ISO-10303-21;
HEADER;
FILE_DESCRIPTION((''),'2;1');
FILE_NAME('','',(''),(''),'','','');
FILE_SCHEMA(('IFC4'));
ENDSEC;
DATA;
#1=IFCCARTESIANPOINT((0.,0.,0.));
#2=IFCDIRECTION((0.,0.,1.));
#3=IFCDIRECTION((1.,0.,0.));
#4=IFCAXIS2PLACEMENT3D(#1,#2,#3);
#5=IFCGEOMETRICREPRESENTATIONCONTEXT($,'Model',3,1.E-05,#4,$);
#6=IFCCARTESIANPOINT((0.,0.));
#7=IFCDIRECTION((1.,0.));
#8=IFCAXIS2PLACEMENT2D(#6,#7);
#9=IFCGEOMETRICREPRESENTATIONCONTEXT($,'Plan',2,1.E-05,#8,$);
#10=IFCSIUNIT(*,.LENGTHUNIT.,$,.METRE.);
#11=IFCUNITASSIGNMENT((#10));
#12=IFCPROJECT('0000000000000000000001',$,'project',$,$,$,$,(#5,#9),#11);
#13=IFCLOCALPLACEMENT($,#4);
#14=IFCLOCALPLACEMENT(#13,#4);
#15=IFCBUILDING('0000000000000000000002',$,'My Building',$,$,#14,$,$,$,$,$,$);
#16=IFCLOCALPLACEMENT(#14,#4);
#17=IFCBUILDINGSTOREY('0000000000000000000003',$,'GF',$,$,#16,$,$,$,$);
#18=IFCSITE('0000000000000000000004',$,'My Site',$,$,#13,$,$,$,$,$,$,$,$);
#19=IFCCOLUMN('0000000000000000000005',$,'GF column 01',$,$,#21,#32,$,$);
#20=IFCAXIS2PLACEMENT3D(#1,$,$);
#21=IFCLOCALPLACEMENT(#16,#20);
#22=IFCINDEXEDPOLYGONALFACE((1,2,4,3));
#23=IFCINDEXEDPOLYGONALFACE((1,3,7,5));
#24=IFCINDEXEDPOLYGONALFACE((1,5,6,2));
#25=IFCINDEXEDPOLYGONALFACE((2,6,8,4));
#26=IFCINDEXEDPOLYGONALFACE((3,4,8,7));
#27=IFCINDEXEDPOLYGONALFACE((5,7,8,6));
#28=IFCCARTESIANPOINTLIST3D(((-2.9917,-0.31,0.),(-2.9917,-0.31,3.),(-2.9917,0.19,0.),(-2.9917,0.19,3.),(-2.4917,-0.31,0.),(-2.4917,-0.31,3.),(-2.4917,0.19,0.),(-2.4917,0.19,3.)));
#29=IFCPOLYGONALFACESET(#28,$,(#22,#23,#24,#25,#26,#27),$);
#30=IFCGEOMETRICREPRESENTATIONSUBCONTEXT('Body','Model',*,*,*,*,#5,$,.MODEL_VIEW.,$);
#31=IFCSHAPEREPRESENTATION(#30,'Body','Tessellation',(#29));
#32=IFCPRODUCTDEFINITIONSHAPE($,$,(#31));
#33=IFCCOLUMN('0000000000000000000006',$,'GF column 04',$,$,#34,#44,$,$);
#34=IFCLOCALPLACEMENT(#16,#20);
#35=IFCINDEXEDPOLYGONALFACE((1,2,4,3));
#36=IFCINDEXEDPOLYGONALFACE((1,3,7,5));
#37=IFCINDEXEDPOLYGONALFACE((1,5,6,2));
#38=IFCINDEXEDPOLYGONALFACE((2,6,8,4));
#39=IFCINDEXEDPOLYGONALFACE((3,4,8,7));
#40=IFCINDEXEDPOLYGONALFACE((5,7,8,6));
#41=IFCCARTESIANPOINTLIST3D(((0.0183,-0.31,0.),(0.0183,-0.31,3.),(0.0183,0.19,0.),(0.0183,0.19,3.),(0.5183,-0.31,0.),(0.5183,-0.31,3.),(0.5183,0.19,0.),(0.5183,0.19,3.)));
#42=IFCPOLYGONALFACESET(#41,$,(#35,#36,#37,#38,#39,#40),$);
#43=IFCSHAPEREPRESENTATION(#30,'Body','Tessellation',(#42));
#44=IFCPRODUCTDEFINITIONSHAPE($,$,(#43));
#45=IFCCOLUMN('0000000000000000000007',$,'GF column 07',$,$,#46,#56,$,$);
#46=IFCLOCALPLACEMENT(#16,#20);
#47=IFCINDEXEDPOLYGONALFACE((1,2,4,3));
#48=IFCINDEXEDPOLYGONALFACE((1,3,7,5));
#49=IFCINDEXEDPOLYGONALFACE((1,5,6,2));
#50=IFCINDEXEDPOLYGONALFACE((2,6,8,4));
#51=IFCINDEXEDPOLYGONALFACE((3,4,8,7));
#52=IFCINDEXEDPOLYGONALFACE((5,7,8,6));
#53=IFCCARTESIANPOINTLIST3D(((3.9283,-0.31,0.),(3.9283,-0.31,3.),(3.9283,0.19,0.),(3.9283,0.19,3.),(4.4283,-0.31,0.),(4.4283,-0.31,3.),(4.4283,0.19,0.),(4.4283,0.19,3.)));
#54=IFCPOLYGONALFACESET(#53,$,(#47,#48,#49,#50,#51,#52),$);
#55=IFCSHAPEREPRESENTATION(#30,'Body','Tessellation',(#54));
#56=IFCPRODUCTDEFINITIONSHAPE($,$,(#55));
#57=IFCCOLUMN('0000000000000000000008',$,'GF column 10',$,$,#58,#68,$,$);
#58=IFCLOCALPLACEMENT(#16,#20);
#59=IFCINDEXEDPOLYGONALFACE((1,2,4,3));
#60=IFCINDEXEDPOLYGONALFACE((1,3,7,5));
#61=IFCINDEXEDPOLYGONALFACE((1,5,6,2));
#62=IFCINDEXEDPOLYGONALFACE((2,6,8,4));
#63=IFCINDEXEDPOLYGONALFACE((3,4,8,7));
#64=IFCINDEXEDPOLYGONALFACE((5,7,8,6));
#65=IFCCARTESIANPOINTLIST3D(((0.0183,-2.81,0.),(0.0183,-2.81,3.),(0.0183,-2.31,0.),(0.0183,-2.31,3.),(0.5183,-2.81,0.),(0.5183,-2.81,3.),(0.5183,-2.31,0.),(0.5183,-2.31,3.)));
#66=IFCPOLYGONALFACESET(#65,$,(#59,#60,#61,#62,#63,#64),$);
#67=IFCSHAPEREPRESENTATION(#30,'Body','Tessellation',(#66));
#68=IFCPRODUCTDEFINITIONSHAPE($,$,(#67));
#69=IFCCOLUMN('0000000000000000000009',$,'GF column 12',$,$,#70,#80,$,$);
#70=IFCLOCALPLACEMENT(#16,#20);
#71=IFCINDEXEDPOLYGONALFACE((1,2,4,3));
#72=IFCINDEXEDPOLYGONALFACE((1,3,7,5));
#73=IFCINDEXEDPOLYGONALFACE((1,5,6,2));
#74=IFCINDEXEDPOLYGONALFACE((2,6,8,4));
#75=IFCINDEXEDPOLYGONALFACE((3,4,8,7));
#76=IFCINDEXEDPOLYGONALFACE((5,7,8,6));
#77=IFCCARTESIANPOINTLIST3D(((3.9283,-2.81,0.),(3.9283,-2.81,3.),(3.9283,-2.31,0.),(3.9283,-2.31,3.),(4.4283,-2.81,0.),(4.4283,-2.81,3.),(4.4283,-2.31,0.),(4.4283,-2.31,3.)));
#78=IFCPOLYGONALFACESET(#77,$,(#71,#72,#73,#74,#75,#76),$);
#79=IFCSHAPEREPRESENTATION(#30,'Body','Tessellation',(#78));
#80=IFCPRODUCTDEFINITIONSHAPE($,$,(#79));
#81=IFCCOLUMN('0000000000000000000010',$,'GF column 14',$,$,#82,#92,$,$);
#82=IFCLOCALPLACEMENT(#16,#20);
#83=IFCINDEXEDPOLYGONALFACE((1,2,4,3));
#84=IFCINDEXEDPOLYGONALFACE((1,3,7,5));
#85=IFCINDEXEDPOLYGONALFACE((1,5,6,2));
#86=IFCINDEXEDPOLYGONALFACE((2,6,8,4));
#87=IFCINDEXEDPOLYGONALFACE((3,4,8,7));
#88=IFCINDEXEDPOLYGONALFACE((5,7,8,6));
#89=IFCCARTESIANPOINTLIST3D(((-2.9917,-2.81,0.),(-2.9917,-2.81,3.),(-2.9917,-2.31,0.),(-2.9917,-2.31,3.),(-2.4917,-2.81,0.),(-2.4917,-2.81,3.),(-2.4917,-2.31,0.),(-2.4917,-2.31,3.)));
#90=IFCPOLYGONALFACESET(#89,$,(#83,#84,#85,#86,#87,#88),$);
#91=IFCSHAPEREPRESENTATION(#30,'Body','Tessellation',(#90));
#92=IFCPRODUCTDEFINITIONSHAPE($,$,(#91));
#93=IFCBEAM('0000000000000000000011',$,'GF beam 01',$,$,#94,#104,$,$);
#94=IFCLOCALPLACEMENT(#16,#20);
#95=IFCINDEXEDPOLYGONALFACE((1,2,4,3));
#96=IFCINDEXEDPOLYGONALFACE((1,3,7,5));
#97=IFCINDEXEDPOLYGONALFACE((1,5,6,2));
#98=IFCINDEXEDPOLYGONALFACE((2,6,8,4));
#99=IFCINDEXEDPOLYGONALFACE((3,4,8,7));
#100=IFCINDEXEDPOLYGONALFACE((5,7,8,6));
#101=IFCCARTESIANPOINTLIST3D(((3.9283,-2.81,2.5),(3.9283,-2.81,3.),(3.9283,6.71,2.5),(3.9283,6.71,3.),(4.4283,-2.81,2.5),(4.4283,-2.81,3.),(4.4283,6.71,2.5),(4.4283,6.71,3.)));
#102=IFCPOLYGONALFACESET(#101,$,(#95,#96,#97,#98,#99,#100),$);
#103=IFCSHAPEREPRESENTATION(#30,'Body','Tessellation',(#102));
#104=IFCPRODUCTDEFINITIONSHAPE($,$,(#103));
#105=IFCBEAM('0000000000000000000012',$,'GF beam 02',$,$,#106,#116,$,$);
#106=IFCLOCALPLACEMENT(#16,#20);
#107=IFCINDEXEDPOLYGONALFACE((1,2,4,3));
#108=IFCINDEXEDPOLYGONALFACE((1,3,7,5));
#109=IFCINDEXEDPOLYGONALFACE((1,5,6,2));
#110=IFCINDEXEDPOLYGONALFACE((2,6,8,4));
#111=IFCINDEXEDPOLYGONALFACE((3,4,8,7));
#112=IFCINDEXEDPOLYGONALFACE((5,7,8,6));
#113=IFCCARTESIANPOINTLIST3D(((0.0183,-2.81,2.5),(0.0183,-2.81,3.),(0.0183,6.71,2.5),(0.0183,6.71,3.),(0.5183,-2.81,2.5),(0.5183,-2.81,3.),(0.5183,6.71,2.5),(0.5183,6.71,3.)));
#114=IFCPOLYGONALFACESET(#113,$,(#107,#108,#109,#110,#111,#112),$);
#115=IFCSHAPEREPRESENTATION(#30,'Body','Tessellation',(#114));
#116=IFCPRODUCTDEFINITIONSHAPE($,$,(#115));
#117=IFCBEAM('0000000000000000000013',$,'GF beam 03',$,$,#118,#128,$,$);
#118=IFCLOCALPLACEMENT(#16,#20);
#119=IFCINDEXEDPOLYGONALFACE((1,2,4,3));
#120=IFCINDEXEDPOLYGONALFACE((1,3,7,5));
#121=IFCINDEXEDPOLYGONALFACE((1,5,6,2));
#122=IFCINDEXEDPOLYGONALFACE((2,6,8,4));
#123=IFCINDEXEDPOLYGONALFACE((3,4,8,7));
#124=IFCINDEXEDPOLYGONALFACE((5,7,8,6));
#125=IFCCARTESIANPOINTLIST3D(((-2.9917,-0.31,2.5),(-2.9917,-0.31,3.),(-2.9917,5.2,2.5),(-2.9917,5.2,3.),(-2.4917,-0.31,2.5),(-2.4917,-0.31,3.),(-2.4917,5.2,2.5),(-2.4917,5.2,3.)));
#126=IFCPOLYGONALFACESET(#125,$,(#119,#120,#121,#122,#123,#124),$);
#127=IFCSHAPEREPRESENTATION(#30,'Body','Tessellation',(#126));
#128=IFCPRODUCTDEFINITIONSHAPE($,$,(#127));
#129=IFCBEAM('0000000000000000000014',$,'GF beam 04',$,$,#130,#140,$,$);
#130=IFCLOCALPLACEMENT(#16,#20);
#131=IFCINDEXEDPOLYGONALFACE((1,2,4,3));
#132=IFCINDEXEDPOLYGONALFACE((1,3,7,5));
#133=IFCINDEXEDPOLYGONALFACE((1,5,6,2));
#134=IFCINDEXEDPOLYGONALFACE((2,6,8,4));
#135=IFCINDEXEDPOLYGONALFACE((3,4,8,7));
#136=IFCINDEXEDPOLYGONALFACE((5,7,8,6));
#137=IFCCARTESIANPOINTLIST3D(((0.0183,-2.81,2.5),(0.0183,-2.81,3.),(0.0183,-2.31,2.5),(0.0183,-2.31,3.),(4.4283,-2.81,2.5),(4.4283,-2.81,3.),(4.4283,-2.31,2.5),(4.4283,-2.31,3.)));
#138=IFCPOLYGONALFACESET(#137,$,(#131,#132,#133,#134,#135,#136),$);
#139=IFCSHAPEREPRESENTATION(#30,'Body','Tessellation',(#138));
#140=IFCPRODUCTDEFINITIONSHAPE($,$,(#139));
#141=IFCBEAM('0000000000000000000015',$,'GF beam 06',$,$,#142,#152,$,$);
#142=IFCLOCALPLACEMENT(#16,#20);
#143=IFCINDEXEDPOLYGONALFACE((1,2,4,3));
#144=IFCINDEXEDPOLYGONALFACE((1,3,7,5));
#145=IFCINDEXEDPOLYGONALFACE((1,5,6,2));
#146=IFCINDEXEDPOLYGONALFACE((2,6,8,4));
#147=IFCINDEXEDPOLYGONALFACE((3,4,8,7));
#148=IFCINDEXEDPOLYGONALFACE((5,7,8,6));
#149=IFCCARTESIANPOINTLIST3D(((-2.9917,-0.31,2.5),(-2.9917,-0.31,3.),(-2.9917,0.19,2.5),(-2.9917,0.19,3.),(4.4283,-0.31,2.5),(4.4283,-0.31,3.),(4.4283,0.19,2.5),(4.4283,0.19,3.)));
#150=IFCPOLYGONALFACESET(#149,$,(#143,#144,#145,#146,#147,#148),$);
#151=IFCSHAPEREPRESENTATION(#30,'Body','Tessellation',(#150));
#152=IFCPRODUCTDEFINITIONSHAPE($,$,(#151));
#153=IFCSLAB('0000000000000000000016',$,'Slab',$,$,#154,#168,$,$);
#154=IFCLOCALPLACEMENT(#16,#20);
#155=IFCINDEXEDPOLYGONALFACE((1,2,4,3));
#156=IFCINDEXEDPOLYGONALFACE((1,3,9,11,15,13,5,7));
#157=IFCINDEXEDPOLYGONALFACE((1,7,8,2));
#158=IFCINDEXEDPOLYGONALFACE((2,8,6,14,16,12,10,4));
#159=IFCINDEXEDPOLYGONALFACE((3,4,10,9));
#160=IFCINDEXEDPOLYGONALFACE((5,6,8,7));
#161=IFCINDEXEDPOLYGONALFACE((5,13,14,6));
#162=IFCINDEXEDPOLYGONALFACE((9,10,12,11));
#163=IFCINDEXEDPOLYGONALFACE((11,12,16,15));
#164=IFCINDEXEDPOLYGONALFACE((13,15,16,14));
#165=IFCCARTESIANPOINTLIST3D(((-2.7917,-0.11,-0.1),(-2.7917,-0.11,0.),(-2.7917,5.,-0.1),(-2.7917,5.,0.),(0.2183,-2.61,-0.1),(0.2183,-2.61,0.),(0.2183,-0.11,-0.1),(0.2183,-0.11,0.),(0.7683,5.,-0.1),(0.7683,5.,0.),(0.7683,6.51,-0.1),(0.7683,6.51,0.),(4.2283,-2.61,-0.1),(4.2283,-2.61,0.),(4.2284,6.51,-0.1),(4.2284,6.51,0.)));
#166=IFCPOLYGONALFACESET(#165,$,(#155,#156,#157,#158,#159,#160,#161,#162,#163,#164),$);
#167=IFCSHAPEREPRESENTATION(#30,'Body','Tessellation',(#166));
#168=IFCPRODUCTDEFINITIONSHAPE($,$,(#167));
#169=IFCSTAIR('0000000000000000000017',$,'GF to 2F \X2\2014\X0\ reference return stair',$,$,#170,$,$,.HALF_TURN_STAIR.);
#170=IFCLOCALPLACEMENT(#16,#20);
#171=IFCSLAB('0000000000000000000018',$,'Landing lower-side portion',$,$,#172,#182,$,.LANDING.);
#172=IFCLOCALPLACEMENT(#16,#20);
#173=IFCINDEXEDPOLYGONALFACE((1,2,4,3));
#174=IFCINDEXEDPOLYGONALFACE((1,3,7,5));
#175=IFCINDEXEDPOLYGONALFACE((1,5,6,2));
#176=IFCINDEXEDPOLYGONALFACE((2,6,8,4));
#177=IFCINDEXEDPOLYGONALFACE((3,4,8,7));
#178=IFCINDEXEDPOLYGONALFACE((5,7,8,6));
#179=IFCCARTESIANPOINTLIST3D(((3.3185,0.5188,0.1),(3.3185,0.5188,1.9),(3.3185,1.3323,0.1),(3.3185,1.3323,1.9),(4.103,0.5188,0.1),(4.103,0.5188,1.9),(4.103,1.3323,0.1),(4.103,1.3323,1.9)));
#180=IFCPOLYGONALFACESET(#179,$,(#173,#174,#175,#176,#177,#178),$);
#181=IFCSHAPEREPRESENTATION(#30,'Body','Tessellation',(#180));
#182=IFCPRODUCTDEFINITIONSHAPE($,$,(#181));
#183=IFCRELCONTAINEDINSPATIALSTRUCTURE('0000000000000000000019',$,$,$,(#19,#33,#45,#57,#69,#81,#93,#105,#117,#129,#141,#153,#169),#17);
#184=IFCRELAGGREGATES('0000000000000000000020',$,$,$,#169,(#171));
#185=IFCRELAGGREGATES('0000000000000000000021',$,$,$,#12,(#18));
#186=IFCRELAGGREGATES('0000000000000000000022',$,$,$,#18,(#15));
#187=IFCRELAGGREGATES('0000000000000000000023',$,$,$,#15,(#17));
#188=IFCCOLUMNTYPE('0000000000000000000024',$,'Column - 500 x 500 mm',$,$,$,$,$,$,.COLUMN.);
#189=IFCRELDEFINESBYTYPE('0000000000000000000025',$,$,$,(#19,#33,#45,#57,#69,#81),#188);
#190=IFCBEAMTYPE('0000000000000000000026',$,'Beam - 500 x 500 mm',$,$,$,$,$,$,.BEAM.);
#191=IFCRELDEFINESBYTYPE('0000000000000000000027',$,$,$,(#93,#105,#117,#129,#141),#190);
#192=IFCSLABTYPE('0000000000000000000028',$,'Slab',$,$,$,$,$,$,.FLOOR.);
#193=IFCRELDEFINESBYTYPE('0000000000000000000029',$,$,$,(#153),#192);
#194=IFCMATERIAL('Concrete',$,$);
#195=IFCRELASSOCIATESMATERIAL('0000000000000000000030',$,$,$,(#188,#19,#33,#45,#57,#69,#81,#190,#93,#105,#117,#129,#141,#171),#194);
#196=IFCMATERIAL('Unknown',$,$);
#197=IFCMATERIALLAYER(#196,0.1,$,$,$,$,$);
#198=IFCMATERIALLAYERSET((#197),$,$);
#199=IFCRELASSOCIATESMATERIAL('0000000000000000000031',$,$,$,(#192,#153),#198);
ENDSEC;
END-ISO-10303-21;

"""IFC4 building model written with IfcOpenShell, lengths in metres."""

from ifc_helpers import new_model, si_unit, frame, origin_with_axes, origin_2d_with_axis, place, context, subcontext, project, spatial, indexed_curve, rectangle, outline, extrude, material, layer, layer_set, layer_usage, material_profile, profile_set, profile_usage, type_object, element, aggregate, save


model = new_model("IFC4")

# Units and contexts
model_context_1 = context("Model", 3, precision=1e-05, world=origin_with_axes())
plan_context = context("Plan", 2, precision=1e-05, world=origin_2d_with_axis())
body_context_1 = subcontext(model_context_1, "Body", "Model", "MODEL_VIEW")
ifc_project = project(units=[si_unit("LENGTHUNIT", "METRE")], contexts=[model_context_1, plan_context])

# Site, building, storey
site_placement = place(None, origin_with_axes())
site = spatial("IfcSite", under=ifc_project, at=site_placement, Name="My Site")
building_placement = place(site_placement, origin_with_axes())
building = spatial("IfcBuilding", under=site, at=building_placement, Name="My Building")
storey_placement = place(building_placement, origin_with_axes())
storey = spatial("IfcBuildingStorey", under=building, at=storey_placement, Name="GF")

# Columns
ifc_material_1 = material(Name="Concrete")
ifc_material_profile_1 = material_profile(ifc_material_1, rectangle(XDim=0.5, YDim=0.5))
ifc_profile_set_1 = profile_set([ifc_material_profile_1])
ifc_profile_usage_1 = profile_usage(ifc_profile_set_1, cardinal=5)
column_type = type_object("IfcColumnType", Name="Column - 500 x 500 mm", PredefinedType="COLUMN", material=ifc_profile_set_1)
column_1_placement = place(storey_placement, frame((-2.7417, -0.06, 0.0), z_axis=(0.0, 0.0, 1.0), x_axis=(1.0, 0.0, 0.0)))
element("IfcColumn", 1, at=column_1_placement, inside=storey, type_object=column_type, material=ifc_profile_usage_1, Name="GF column 01", context=body_context_1, shape_type="SweptSolid", body=[
    extrude(rectangle(XDim=0.5, YDim=0.5), origin_with_axes(), (0.0, 0.0, 1.0), 3.0),
])
ifc_profile_usage_2 = profile_usage(ifc_profile_set_1, cardinal=5)
column_2_placement = place(storey_placement, frame((0.2683, -0.06, 0.0), z_axis=(0.0, 0.0, 1.0), x_axis=(1.0, 0.0, 0.0)))
element("IfcColumn", 2, at=column_2_placement, inside=storey, type_object=column_type, material=ifc_profile_usage_2, Name="GF column 04", context=body_context_1, shape_type="SweptSolid", body=[
    extrude(rectangle(XDim=0.5, YDim=0.5), origin_with_axes(), (0.0, 0.0, 1.0), 3.0),
])
ifc_profile_usage_3 = profile_usage(ifc_profile_set_1, cardinal=5)
column_3_placement = place(storey_placement, frame((4.1783, -0.06, 0.0), z_axis=(0.0, 0.0, 1.0), x_axis=(1.0, 0.0, 0.0)))
element("IfcColumn", 3, at=column_3_placement, inside=storey, type_object=column_type, material=ifc_profile_usage_3, Name="GF column 07", context=body_context_1, shape_type="SweptSolid", body=[
    extrude(rectangle(XDim=0.5, YDim=0.5), origin_with_axes(), (0.0, 0.0, 1.0), 3.0),
])
ifc_profile_usage_4 = profile_usage(ifc_profile_set_1, cardinal=5)
column_4_placement = place(storey_placement, frame((0.2683, -2.56, 0.0), z_axis=(0.0, 0.0, 1.0), x_axis=(1.0, 0.0, 0.0)))
element("IfcColumn", 4, at=column_4_placement, inside=storey, type_object=column_type, material=ifc_profile_usage_4, Name="GF column 10", context=body_context_1, shape_type="SweptSolid", body=[
    extrude(rectangle(XDim=0.5, YDim=0.5), origin_with_axes(), (0.0, 0.0, 1.0), 3.0),
])
ifc_profile_usage_5 = profile_usage(ifc_profile_set_1, cardinal=5)
column_5_placement = place(storey_placement, frame((4.1783, -2.56, 0.0), z_axis=(0.0, 0.0, 1.0), x_axis=(1.0, 0.0, 0.0)))
element("IfcColumn", 5, at=column_5_placement, inside=storey, type_object=column_type, material=ifc_profile_usage_5, Name="GF column 12", context=body_context_1, shape_type="SweptSolid", body=[
    extrude(rectangle(XDim=0.5, YDim=0.5), origin_with_axes(), (0.0, 0.0, 1.0), 3.0),
])
ifc_profile_usage_6 = profile_usage(ifc_profile_set_1, cardinal=5)
column_6_placement = place(storey_placement, frame((-2.7417, -2.56, 0.0), z_axis=(0.0, 0.0, 1.0), x_axis=(1.0, 0.0, 0.0)))
element("IfcColumn", 6, at=column_6_placement, inside=storey, type_object=column_type, material=ifc_profile_usage_6, Name="GF column 14", context=body_context_1, shape_type="SweptSolid", body=[
    extrude(rectangle(XDim=0.5, YDim=0.5), origin_with_axes(), (0.0, 0.0, 1.0), 3.0),
])

# Beams
ifc_material_profile_2 = material_profile(ifc_material_1, rectangle(XDim=0.5, YDim=0.5))
ifc_profile_set_2 = profile_set([ifc_material_profile_2])
ifc_profile_usage_7 = profile_usage(ifc_profile_set_2, cardinal=5)
beam_type = type_object("IfcBeamType", Name="Beam - 500 x 500 mm", PredefinedType="BEAM", material=ifc_profile_set_2)
beam_1_placement = place(storey_placement, frame((4.1783, -2.81, 2.75), z_axis=(0.0, 1.0, 0.0), x_axis=(0.0, 0.0, 1.0)))
element("IfcBeam", 7, at=beam_1_placement, inside=storey, type_object=beam_type, material=ifc_profile_usage_7, Name="GF beam 01", context=body_context_1, shape_type="SweptSolid", body=[
    extrude(rectangle(XDim=0.5, YDim=0.5), origin_with_axes(), (0.0, 0.0, 1.0), 9.52),
])
ifc_profile_usage_8 = profile_usage(ifc_profile_set_2, cardinal=5)
beam_2_placement = place(storey_placement, frame((0.2683, -2.81, 2.75), z_axis=(0.0, 1.0, 0.0), x_axis=(0.0, 0.0, 1.0)))
element("IfcBeam", 8, at=beam_2_placement, inside=storey, type_object=beam_type, material=ifc_profile_usage_8, Name="GF beam 02", context=body_context_1, shape_type="SweptSolid", body=[
    extrude(rectangle(XDim=0.5, YDim=0.5), origin_with_axes(), (0.0, 0.0, 1.0), 9.52),
])
ifc_profile_usage_9 = profile_usage(ifc_profile_set_2, cardinal=5)
beam_3_placement = place(storey_placement, frame((-2.7417, -0.31, 2.75), z_axis=(0.0, 1.0, 0.0), x_axis=(0.0, 0.0, 1.0)))
element("IfcBeam", 9, at=beam_3_placement, inside=storey, type_object=beam_type, material=ifc_profile_usage_9, Name="GF beam 03", context=body_context_1, shape_type="SweptSolid", body=[
    extrude(rectangle(XDim=0.5, YDim=0.5), origin_with_axes(), (0.0, 0.0, 1.0), 5.51),
])
ifc_profile_usage_10 = profile_usage(ifc_profile_set_2, cardinal=5)
beam_4_placement = place(storey_placement, frame((0.0183, -2.56, 2.75), z_axis=(1.0, 0.0, 0.0), x_axis=(0.0, 0.0, 1.0)))
element("IfcBeam", 10, at=beam_4_placement, inside=storey, type_object=beam_type, material=ifc_profile_usage_10, Name="GF beam 04", context=body_context_1, shape_type="SweptSolid", body=[
    extrude(rectangle(XDim=0.5, YDim=0.5), origin_with_axes(), (0.0, 0.0, 1.0), 4.41),
])
ifc_profile_usage_11 = profile_usage(ifc_profile_set_2, cardinal=5)
beam_5_placement = place(storey_placement, frame((-2.9917, -0.06, 2.75), z_axis=(1.0, 0.0, 0.0), x_axis=(0.0, 0.0, 1.0)))
element("IfcBeam", 11, at=beam_5_placement, inside=storey, type_object=beam_type, material=ifc_profile_usage_11, Name="GF beam 06", context=body_context_1, shape_type="SweptSolid", body=[
    extrude(rectangle(XDim=0.5, YDim=0.5), origin_with_axes(), (0.0, 0.0, 1.0), 7.42),
])

# Slab
ifc_material_2 = material(Name="Unknown")
ifc_layer_1 = layer(ifc_material_2, 0.1)
ifc_layer_set_1 = layer_set([ifc_layer_1])
ifc_layer_usage_1 = layer_usage(ifc_layer_set_1, "AXIS3", "POSITIVE", -0.1)
slab_type = type_object("IfcSlabType", Name="Slab", PredefinedType="FLOOR", material=ifc_layer_set_1)
slab_1_placement = place(storey_placement, frame((0.2183, -2.61, 0.0), z_axis=(0.0, 0.0, 1.0), x_axis=(1.0, 0.0, 0.0)))
element("IfcSlab", 12, at=slab_1_placement, inside=storey, type_object=slab_type, material=ifc_layer_usage_1, Name="Slab", context=body_context_1, shape_type="SweptSolid", body=[
    extrude(outline(indexed_curve([(4.01, 0.0), (4.01, 9.12), (0.55, 9.12), (0.55, 7.61), (-3.01, 7.61), (-3.01, 2.5), (0.0, 2.5), (0.0, 0.0), (4.01, 0.0)])), frame((0.0, 0.0, -0.1), z_axis=(0.0, 0.0, 1.0), x_axis=(1.0, 0.0, 0.0)), (0.0, 0.0, 1.0), 0.1),
])

# Stair, slab
stair_placement = place(storey_placement, origin_with_axes())
stair = element("IfcStair", 13, at=stair_placement, inside=storey, Name="GF to 2F — reference return stair", PredefinedType="HALF_TURN_STAIR")
slab_2_placement = place(stair_placement, frame((0.0, 0.0, 0.1), z_axis=(0.0, 0.0, 1.0), x_axis=(1.0, 0.0, 0.0)))
slab_2 = element("IfcSlab", 14, at=slab_2_placement, material=ifc_material_1, Name="Landing lower-side portion", PredefinedType="LANDING", context=body_context_1, shape_type="SweptSolid", body=[
    extrude(outline(indexed_curve([(3.3185, 0.5188), (4.103, 0.5188), (4.103, 1.3323), (3.3185, 1.3323), (3.3185, 0.5188)])), origin_with_axes(), (0.0, 0.0, 1.0), 1.8),
])
aggregate(stair, [slab_2])

save(model, "model.ifc")
